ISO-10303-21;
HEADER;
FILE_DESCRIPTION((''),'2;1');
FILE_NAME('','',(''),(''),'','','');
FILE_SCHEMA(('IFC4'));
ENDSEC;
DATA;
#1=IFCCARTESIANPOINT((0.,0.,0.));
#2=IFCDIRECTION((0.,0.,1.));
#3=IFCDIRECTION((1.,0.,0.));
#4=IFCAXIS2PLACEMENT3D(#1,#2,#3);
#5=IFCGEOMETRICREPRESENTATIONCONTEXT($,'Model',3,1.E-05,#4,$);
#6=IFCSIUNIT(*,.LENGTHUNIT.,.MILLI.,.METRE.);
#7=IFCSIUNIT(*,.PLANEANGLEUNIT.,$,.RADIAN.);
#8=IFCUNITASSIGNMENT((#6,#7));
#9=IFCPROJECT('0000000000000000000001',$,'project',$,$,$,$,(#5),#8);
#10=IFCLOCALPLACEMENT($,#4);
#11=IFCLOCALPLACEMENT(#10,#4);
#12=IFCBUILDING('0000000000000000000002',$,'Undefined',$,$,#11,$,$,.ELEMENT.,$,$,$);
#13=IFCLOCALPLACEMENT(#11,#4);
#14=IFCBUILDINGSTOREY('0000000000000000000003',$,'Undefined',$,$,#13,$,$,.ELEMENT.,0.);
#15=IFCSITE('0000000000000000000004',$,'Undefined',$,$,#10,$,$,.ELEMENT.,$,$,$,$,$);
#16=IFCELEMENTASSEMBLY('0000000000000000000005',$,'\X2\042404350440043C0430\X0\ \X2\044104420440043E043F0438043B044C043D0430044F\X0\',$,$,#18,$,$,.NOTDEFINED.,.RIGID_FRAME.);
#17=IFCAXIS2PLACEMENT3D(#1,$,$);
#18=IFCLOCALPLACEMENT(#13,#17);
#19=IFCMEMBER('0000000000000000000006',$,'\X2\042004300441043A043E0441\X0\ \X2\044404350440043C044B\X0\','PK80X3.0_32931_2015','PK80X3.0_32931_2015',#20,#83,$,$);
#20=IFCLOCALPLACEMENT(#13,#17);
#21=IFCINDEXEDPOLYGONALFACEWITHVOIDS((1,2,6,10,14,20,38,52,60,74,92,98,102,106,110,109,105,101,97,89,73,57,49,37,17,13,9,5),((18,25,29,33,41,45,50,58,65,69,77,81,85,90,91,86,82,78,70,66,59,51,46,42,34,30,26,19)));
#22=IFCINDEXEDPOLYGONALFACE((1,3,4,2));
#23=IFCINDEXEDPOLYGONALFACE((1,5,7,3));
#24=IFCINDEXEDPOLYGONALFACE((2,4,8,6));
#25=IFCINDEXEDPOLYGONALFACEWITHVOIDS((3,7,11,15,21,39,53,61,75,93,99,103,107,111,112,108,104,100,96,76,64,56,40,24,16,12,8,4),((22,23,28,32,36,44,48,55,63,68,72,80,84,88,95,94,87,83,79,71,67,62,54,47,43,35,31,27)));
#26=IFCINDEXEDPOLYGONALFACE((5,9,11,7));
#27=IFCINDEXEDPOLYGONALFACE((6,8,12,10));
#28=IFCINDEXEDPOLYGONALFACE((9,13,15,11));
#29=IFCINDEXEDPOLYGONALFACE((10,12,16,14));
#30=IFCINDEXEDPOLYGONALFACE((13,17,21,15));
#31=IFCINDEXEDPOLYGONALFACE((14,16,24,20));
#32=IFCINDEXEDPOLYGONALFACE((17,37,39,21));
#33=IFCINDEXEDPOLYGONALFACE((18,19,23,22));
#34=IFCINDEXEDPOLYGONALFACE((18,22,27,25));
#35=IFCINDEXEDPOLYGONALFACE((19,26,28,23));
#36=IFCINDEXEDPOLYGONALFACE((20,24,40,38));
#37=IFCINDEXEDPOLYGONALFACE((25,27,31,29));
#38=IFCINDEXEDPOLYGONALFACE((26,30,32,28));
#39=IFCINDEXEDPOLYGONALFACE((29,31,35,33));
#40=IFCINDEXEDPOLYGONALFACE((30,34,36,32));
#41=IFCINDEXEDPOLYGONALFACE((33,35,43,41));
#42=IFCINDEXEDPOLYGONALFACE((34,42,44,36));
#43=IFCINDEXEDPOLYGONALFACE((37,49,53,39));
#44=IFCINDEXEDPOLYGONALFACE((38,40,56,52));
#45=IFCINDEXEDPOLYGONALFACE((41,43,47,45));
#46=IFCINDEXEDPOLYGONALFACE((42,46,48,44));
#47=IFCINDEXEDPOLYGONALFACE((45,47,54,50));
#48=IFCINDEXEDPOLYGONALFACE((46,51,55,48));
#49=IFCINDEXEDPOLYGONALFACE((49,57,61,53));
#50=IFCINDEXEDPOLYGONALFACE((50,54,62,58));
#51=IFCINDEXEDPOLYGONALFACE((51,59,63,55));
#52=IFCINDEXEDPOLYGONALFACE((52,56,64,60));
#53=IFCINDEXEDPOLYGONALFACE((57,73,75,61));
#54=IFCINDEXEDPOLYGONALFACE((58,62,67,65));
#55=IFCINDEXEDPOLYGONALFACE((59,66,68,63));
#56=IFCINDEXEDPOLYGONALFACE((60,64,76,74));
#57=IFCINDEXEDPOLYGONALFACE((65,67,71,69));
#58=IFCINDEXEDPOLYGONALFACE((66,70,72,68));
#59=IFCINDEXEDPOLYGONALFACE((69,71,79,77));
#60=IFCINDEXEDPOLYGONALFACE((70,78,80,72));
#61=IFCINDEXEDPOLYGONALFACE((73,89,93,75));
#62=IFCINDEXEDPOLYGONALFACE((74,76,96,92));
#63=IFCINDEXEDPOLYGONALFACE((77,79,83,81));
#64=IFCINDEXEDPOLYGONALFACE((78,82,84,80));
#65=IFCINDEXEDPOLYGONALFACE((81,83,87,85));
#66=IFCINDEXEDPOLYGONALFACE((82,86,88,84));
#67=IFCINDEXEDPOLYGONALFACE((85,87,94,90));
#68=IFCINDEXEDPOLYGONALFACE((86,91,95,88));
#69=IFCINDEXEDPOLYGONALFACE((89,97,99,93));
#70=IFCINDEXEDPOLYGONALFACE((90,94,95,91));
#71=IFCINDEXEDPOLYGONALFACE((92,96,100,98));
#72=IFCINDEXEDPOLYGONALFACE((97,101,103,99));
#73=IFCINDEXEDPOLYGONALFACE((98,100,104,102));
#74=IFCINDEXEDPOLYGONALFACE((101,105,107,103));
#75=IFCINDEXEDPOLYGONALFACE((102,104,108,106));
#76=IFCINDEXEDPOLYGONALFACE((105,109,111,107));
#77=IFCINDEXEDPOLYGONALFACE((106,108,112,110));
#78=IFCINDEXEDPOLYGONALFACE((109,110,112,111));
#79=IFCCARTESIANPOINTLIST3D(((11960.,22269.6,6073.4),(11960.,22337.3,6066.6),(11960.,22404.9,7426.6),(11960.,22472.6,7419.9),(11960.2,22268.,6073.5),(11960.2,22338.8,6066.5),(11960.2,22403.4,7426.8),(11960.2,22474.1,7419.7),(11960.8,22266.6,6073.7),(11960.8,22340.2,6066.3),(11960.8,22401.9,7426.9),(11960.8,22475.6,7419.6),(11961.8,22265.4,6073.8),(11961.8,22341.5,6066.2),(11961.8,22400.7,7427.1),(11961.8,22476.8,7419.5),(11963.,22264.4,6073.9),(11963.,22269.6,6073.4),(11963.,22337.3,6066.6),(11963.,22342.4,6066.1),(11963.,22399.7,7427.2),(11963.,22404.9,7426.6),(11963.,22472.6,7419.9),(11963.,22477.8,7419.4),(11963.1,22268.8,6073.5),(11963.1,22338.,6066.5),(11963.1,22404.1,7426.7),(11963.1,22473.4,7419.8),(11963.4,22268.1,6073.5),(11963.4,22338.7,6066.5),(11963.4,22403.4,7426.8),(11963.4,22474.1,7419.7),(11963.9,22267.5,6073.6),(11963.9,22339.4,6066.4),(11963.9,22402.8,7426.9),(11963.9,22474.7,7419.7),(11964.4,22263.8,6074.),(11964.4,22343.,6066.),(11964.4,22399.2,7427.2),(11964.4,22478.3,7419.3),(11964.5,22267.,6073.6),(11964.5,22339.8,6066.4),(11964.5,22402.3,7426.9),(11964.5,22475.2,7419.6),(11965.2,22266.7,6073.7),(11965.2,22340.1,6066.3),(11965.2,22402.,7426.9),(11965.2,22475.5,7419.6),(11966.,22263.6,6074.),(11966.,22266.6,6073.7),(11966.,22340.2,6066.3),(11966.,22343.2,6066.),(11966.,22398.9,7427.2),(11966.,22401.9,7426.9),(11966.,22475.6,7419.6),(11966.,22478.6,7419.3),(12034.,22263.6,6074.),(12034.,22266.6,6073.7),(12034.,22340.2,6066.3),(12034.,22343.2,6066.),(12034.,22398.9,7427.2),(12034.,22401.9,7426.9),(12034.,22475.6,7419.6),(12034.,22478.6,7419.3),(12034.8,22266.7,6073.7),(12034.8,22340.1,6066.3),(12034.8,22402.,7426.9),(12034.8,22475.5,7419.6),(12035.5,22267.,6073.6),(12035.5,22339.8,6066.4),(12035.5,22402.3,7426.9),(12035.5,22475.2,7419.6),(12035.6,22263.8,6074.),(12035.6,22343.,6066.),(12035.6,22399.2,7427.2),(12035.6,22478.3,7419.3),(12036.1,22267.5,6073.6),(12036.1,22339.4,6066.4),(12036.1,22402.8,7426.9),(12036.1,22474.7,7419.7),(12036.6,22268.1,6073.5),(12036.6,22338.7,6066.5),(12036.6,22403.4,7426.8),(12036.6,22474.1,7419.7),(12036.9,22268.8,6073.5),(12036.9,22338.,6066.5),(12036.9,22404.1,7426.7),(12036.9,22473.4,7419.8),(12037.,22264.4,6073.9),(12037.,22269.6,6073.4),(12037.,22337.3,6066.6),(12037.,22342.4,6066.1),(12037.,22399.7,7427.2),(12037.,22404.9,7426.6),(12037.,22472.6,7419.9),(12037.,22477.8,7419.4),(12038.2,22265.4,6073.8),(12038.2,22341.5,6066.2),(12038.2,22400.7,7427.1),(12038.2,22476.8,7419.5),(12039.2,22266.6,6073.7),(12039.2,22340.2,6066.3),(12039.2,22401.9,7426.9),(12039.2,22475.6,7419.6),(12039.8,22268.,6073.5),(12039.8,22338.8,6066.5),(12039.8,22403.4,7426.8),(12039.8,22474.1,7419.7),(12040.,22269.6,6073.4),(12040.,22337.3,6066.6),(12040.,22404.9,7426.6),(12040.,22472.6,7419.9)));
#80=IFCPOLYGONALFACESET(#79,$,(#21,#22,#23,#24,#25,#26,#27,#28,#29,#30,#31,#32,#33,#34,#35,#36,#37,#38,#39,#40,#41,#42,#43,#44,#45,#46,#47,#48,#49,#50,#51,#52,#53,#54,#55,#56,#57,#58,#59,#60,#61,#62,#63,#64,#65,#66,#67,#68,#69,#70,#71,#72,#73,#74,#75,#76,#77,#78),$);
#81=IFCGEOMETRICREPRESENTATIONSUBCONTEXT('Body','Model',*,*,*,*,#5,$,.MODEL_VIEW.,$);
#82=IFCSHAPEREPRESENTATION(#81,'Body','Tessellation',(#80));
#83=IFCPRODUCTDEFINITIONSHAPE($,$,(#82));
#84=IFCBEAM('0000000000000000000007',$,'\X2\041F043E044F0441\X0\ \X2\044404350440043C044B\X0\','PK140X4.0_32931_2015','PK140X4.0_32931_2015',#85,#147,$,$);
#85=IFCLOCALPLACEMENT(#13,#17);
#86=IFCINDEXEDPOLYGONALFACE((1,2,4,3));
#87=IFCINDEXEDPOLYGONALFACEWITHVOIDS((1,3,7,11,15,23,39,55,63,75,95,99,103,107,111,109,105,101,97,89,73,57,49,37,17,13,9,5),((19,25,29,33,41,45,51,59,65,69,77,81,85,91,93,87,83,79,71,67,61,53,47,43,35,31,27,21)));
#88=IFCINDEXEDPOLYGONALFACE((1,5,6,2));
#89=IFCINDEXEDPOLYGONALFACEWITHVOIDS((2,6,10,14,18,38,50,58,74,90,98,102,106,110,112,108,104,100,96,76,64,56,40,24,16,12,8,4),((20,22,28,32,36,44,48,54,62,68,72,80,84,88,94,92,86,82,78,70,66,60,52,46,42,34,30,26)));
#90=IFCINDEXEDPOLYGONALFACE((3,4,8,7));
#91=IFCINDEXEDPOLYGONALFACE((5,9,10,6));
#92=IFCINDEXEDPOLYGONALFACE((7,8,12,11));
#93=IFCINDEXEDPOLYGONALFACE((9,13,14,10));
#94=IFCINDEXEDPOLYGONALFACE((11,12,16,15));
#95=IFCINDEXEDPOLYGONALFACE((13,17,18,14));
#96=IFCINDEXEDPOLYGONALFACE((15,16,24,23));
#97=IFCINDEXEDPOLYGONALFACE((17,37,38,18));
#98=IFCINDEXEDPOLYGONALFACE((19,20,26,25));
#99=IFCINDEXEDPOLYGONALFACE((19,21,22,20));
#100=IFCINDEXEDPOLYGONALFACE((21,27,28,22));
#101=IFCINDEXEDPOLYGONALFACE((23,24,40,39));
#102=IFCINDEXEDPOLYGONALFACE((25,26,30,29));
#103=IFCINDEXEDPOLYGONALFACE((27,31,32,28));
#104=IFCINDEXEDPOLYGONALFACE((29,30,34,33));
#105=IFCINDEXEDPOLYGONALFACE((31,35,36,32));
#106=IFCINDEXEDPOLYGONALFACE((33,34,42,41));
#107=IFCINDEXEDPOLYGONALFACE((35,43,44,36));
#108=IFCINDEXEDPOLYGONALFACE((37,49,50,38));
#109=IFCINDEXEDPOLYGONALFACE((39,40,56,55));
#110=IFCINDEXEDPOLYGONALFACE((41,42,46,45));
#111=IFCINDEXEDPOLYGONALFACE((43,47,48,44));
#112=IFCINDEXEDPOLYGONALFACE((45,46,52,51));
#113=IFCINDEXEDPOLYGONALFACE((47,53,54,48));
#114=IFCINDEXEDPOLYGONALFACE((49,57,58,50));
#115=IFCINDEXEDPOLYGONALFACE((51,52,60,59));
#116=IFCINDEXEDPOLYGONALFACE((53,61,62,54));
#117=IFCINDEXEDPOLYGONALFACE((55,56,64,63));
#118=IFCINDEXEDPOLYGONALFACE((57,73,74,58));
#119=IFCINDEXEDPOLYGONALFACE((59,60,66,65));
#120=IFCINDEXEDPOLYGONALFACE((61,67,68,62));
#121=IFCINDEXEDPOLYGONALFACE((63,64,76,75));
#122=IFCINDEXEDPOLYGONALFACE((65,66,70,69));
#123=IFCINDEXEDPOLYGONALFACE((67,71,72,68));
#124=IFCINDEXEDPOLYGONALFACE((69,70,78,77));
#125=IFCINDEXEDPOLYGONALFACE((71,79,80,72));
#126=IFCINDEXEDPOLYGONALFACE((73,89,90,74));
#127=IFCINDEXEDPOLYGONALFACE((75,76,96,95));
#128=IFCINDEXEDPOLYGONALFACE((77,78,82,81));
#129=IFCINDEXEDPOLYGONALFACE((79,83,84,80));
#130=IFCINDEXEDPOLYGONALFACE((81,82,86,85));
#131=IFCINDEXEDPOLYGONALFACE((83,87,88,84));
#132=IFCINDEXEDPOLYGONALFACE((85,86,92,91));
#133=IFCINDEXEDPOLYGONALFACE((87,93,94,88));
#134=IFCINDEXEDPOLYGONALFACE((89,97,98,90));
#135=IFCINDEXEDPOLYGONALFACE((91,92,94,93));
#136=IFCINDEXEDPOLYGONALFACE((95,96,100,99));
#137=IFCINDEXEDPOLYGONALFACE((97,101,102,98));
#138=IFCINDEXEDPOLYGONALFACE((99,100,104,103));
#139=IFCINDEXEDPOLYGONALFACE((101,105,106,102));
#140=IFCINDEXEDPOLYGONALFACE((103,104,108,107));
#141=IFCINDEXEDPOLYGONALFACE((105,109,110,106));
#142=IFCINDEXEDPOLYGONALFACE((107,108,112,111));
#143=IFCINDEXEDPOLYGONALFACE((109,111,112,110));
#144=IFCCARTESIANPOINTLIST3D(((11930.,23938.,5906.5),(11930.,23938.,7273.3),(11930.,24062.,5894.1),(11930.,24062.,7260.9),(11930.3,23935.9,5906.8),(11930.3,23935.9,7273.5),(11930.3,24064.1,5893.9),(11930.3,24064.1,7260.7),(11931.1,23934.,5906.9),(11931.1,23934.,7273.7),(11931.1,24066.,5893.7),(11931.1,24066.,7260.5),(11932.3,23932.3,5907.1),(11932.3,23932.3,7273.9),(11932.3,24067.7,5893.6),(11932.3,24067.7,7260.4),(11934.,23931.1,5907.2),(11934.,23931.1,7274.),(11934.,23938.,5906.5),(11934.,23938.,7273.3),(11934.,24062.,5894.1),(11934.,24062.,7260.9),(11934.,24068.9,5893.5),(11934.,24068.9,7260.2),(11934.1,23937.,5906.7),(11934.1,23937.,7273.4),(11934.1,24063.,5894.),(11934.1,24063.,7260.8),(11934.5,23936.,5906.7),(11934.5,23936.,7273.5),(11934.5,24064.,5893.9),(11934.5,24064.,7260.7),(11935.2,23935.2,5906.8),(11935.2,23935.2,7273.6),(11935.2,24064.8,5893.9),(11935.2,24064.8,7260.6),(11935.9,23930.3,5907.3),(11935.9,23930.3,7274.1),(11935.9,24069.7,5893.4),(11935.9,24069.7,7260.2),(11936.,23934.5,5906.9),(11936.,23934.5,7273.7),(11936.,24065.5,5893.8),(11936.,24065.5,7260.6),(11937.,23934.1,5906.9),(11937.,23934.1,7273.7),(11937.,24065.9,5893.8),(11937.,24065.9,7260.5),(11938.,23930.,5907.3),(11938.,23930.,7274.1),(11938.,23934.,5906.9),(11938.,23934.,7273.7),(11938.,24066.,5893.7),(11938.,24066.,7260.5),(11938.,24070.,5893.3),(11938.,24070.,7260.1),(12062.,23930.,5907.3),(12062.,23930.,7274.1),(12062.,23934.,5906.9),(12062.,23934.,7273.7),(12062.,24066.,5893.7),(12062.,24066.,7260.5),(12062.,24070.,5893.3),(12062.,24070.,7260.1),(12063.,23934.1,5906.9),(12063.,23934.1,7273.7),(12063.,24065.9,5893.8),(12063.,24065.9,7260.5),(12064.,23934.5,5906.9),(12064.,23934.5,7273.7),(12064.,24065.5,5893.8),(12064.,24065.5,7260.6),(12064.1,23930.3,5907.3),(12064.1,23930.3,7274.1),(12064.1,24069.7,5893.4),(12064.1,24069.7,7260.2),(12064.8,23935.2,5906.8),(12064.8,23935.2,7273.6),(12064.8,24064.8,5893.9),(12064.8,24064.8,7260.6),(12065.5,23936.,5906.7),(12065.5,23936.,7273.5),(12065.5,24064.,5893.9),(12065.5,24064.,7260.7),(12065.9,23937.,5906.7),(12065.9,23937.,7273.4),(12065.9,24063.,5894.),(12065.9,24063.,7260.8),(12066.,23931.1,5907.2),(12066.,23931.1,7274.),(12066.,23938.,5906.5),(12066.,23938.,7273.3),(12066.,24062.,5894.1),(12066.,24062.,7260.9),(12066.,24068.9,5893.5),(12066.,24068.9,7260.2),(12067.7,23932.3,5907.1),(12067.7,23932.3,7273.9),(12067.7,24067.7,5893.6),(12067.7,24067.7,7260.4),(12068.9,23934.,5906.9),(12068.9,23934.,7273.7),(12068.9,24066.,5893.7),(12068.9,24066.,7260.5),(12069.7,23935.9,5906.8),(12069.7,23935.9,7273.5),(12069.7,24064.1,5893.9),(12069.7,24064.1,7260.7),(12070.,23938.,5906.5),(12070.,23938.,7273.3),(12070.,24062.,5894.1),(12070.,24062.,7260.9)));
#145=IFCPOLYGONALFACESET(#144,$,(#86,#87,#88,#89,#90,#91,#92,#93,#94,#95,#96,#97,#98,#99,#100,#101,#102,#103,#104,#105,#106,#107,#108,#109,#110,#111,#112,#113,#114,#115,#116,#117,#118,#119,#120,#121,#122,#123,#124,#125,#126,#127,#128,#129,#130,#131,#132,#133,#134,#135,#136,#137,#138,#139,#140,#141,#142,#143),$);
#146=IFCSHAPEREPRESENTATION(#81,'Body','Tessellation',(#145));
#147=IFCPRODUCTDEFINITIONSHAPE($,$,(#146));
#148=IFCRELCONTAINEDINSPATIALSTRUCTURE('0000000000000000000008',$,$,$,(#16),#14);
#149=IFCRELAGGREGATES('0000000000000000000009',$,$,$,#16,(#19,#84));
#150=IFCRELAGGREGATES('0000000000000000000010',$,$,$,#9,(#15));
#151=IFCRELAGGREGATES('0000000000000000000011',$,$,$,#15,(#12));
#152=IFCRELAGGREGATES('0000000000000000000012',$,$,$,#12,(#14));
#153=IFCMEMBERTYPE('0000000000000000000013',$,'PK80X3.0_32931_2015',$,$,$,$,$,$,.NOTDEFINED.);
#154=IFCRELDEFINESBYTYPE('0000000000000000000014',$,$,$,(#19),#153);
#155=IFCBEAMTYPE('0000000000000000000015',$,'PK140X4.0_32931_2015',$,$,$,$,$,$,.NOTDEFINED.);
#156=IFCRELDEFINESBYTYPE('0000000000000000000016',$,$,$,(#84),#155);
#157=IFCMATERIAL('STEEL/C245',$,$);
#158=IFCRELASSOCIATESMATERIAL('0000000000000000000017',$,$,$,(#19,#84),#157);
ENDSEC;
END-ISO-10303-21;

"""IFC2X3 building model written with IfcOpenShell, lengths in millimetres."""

from ifc_helpers import new_model, si_unit, frame, origin_with_axes, origin_2d_with_axis, place, context, subcontext, project, spatial, hollow_rectangle, extrude, clip, halfspace, material, type_object, element, aggregate, save


model = new_model("IFC2X3")

# Units and contexts
model_context = context("Model", 3, precision=1e-05, world=origin_with_axes())
body_context = subcontext(model_context, "Body", "Model", "MODEL_VIEW")
ifc_project = project(units=[si_unit("LENGTHUNIT", "METRE", prefix="MILLI"), si_unit("PLANEANGLEUNIT", "RADIAN")], contexts=[model_context])

# Site, building, storey
site_placement = place(None, origin_with_axes())
site = spatial("IfcSite", under=ifc_project, at=site_placement, Name="Undefined", CompositionType="ELEMENT")
building_placement = place(site_placement, origin_with_axes())
building = spatial("IfcBuilding", under=site, at=building_placement, Name="Undefined", CompositionType="ELEMENT")
storey_placement = place(building_placement, origin_with_axes())
storey = spatial("IfcBuildingStorey", under=building, at=storey_placement, Name="Undefined", CompositionType="ELEMENT", Elevation=0.0)

# Shared definitions
ifc_material_1 = material(Name="STEEL/C245")

# Shared definitions
member_type_1 = type_object("IfcMemberType", Name="PK80X3.0_32931_2015", PredefinedType="NOTDEFINED")

# Element assembly, member
assembly_1_placement = place(storey_placement, origin_with_axes())
assembly_1 = element("IfcElementAssembly", 1, at=assembly_1_placement, inside=storey, Name="Ферма стропильная", AssemblyPlace="NOTDEFINED", PredefinedType="RIGID_FRAME")
member_1_placement = place(assembly_1_placement, frame((12000.0, 22438.7, 7423.3), z_axis=(0.0, -0.995037, 0.099504), x_axis=(0.0, -0.099504, -0.995037)))
member_1 = element("IfcMember", 2, at=member_1_placement, type_object=member_type_1, material=ifc_material_1, Name="Раскос фермы", Description="PK80X3.0_32931_2015", ObjectType="PK80X3.0_32931_2015", context=body_context, shape_type="SweptSolid", body=[
    extrude(hollow_rectangle(XDim=80.0, YDim=80.0, WallThickness=3.0, InnerFilletRadius=3.0, OuterFilletRadius=6.0, at=origin_2d_with_axis()), frame((1360.0, 0.0, 0.0), z_axis=(-1.0, 0.0, 0.0), x_axis=(0.0, -1.0, 0.0)), (0.0, 0.0, 1.0), 1360.0),
])

# Beam
beam_type_1 = type_object("IfcBeamType", Name="PK140X4.0_32931_2015", PredefinedType="NOTDEFINED")
beam_1_placement = place(assembly_1_placement, frame((12000.0, 24000.0, 7260.1), z_axis=(1.0, 0.0, 0.0), x_axis=(0.0, 0.0, -1.0)))
beam_1 = element("IfcBeam", 3, at=beam_1_placement, type_object=beam_type_1, material=ifc_material_1, Name="Пояс фермы", Description="PK140X4.0_32931_2015", ObjectType="PK140X4.0_32931_2015", context=body_context, shape_type="Clipping", body=[
    clip(clip(extrude(hollow_rectangle(XDim=140.0, YDim=140.0, WallThickness=4.0, InnerFilletRadius=4.0, OuterFilletRadius=8.0, at=origin_2d_with_axis()), frame((1373.9, 0.0, 0.0), z_axis=(-1.0, 0.0, 0.0), x_axis=(0.0, -1.0, 0.0)), (0.0, 0.0, 1.0), 1395.1), halfspace(frame((1348.5, -112.4, 0.0), z_axis=(0.995037, -0.099504, 0.0), x_axis=(-0.099504, -0.995037, 0.0)), False)), halfspace(frame((-20.7, -136.7, 0.0), z_axis=(0.995037, -0.099504, 0.0), x_axis=(-0.099504, -0.995037, 0.0)), True)),
])

aggregate(assembly_1, [member_1, beam_1])

save(model, "model.ifc")
